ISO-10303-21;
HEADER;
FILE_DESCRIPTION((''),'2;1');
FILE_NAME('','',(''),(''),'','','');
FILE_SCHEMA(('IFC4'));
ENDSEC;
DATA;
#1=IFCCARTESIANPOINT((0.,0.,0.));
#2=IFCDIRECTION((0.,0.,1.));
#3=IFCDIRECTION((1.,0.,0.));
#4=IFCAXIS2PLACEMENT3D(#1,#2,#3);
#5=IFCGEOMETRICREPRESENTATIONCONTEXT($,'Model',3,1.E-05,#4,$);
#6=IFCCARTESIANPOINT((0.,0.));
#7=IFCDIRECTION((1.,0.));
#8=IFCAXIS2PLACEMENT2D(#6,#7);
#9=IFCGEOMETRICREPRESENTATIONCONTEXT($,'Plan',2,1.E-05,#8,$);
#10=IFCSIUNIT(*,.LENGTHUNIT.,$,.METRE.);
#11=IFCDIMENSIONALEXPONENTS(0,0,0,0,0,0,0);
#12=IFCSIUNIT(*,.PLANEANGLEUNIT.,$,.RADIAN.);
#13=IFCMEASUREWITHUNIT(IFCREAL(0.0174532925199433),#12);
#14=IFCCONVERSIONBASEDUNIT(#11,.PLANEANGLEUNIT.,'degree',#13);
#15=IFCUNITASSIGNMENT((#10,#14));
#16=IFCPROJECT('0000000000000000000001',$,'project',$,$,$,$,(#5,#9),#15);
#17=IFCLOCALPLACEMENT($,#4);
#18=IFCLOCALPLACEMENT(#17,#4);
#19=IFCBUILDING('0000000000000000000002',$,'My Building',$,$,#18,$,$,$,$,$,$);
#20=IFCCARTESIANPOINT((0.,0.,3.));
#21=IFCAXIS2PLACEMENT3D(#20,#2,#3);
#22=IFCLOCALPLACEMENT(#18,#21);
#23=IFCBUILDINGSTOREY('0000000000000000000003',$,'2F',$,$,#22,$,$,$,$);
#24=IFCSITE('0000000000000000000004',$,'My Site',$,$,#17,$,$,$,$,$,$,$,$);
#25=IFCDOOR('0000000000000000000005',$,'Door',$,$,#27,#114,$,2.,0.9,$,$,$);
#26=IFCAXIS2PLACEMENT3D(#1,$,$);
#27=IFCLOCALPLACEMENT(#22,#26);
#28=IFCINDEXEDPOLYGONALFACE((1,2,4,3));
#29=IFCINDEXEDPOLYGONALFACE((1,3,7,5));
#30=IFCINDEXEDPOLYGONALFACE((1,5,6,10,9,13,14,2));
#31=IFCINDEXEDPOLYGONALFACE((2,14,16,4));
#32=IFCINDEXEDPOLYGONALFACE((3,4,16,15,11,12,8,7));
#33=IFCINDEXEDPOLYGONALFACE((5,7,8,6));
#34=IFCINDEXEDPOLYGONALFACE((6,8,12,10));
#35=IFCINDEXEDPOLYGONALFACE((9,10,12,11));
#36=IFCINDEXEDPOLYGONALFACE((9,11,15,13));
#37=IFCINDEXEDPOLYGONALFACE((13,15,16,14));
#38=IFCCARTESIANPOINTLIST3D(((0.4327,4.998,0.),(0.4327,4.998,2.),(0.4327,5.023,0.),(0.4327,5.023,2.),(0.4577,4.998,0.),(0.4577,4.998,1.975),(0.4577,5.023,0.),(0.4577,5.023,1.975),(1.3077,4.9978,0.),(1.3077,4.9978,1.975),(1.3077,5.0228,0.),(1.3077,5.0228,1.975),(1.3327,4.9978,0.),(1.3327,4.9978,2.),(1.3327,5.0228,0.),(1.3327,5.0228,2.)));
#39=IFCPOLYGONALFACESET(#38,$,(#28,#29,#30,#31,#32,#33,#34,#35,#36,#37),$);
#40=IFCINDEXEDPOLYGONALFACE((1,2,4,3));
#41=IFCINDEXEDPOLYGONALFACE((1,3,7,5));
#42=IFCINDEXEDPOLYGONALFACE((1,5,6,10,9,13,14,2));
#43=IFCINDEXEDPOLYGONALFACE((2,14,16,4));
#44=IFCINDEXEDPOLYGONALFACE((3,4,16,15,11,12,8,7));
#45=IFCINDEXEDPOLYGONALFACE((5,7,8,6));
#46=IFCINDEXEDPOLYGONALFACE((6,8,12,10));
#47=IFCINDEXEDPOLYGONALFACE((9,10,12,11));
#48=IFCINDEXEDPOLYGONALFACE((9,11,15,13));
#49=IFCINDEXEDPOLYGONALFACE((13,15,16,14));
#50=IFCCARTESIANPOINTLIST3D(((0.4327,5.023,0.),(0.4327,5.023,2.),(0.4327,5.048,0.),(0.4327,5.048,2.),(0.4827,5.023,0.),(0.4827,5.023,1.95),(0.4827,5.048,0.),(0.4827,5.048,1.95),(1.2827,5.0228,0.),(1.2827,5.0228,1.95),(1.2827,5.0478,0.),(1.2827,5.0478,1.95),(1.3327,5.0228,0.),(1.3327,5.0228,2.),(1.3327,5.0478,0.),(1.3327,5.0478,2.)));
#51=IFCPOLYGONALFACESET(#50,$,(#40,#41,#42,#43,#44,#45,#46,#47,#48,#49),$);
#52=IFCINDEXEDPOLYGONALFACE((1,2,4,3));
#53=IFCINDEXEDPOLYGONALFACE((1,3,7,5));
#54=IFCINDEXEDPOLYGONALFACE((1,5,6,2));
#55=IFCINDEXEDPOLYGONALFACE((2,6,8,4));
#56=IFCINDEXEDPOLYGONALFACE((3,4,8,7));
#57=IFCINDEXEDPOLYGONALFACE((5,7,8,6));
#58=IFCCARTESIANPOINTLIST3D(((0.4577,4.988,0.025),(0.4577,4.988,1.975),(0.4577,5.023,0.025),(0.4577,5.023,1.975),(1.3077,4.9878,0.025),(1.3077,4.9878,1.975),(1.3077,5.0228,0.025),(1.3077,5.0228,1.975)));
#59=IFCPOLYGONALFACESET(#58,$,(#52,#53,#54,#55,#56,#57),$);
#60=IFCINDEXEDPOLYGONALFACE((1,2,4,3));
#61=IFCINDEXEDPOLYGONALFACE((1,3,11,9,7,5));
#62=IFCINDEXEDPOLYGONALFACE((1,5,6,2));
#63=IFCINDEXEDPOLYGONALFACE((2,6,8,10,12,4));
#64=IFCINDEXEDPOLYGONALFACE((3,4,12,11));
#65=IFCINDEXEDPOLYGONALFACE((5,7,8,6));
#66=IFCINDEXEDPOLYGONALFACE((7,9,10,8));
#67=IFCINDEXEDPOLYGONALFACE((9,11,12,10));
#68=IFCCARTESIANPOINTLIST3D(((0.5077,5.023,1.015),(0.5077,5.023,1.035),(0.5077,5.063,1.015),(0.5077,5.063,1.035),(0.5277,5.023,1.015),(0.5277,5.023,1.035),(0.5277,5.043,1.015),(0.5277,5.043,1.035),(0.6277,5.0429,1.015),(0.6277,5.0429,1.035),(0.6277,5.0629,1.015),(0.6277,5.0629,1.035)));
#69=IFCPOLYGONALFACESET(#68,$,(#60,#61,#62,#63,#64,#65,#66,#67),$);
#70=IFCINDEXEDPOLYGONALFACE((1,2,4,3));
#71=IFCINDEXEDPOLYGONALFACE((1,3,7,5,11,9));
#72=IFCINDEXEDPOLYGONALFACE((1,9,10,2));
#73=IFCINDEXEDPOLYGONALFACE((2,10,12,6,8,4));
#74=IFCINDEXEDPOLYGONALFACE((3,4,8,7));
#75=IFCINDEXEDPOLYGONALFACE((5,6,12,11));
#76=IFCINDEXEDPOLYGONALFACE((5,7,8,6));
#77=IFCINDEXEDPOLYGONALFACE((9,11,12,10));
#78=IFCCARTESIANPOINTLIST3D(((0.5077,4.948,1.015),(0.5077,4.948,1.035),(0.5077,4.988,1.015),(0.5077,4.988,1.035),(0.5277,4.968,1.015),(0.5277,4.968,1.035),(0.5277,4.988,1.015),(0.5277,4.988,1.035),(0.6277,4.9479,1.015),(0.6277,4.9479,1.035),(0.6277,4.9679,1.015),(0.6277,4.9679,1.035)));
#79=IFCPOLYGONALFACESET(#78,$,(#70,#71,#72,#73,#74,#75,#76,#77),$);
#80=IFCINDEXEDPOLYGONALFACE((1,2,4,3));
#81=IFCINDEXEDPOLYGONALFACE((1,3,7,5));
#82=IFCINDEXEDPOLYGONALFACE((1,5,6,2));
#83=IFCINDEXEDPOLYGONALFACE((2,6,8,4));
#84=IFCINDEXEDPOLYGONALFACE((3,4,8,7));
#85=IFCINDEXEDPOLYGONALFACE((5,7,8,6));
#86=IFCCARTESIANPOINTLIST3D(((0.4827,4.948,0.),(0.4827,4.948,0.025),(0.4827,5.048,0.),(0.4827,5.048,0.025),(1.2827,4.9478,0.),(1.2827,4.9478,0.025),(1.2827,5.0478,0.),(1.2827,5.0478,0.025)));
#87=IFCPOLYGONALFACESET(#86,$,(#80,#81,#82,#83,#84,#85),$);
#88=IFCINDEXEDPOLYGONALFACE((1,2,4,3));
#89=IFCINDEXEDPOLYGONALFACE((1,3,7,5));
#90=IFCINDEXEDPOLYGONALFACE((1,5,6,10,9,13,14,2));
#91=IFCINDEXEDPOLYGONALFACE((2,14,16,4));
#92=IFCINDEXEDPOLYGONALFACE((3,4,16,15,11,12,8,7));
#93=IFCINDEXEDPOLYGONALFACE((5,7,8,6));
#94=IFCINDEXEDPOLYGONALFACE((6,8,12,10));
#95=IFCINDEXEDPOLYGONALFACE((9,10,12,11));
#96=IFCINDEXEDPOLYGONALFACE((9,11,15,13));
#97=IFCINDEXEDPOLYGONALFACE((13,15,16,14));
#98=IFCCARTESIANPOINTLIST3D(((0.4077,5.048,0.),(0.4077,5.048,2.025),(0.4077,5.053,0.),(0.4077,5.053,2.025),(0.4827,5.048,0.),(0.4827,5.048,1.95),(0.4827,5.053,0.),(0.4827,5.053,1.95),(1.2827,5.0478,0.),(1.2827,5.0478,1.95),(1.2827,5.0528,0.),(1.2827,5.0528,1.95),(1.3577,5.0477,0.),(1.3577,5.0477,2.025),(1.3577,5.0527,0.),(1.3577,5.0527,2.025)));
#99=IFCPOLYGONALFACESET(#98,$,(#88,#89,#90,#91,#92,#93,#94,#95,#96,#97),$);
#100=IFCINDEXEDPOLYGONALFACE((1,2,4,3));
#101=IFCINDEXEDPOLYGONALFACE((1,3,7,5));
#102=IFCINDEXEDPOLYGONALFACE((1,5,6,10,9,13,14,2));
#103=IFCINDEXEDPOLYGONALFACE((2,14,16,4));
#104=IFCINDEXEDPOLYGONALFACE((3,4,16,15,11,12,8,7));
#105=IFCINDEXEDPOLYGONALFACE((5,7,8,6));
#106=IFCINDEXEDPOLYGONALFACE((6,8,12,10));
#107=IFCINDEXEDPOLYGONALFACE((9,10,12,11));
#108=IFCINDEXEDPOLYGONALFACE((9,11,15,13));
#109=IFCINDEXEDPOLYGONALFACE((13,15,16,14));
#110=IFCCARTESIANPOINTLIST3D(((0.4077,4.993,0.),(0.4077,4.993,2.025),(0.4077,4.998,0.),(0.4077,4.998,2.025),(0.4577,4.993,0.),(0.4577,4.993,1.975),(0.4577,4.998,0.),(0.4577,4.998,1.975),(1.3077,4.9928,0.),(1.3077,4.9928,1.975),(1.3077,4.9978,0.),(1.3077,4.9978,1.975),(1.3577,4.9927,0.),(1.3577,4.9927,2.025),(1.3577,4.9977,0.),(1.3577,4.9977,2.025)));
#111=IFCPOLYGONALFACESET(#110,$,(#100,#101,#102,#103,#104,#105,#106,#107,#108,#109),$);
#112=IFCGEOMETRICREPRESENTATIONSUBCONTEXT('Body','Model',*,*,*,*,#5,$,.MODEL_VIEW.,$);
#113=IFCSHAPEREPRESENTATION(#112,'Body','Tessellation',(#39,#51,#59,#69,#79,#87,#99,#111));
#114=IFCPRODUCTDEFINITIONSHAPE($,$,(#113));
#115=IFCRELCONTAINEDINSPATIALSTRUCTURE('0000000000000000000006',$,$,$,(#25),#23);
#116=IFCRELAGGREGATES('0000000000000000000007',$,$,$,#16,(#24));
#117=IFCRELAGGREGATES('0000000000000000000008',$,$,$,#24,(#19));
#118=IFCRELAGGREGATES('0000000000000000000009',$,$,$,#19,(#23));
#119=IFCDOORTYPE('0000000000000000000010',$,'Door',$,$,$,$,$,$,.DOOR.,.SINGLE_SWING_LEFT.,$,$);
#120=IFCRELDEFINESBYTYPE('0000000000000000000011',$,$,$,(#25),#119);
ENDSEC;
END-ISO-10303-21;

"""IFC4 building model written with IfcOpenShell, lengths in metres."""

from ifc_helpers import new_model, entity, si_unit, converted_unit, frame, origin_with_axes, origin_2d_with_axis, place, context, subcontext, project, spatial, line, indexed_curve, outline, extrude, shape, source, transform, mapped, type_object, type_shapes, element, save


model = new_model("IFC4")

# Units and contexts
model_context = context("Model", 3, precision=1e-05, world=origin_with_axes())
plan_context = context("Plan", 2, precision=1e-05, world=origin_2d_with_axis())
body_context_1 = subcontext(model_context, "Body", "Model", "MODEL_VIEW")
body_context_2 = subcontext(plan_context, "Body", "Plan", "PLAN_VIEW")
ifc_project = project(units=[si_unit("LENGTHUNIT", "METRE"), converted_unit("PLANEANGLEUNIT", "degree", entity("IfcReal", 0.0174532925199433), si_unit("PLANEANGLEUNIT", "RADIAN"), dimensions=[0, 0, 0, 0, 0, 0, 0])], contexts=[model_context, plan_context])

# Site, building, storey
site_placement = place(None, origin_with_axes())
site = spatial("IfcSite", under=ifc_project, at=site_placement, Name="My Site")
building_placement = place(site_placement, origin_with_axes())
building = spatial("IfcBuilding", under=site, at=building_placement, Name="My Building")
storey_placement = place(building_placement, frame((0.0, 0.0, 3.0), z_axis=(0.0, 0.0, 1.0), x_axis=(1.0, 0.0, 0.0)))
storey = spatial("IfcBuildingStorey", under=building, at=storey_placement, Name="2F")

# Shared definitions
door_type_1 = type_object("IfcDoorType", Name="Door", OperationType="SINGLE_SWING_LEFT", PredefinedType="DOOR")
shared_shape_1 = source(origin_with_axes(), body_context_1, "Body", "SweptSolid", [
    extrude(outline(indexed_curve([(0.0, 0.0), (0.0, 2.0), (0.9, 2.0), (0.9, 0.0), (0.875, 0.0), (0.875, 1.975), (0.025, 1.975), (0.025, 0.0)], segments=[line(1, 2, 3, 4, 5, 6, 7, 8, 1)])), frame((0.0, 0.025, 0.0), z_axis=(0.0, -1.0, 0.0), x_axis=(1.0, 0.0, 0.0)), (0.0, 0.0, -1.0), 0.025),
    extrude(outline(indexed_curve([(0.0, 0.0), (0.0, 2.0), (0.9, 2.0), (0.9, 0.0), (0.85, 0.0), (0.85, 1.95), (0.05, 1.95), (0.05, 0.0)], segments=[line(1, 2, 3, 4, 5, 6, 7, 8, 1)])), frame((0.0, 0.0, 0.0), z_axis=(0.0, -1.0, 0.0), x_axis=(1.0, 0.0, 0.0)), (0.0, 0.0, -1.0), 0.025),
    extrude(outline(indexed_curve([(0.0, 0.0), (0.85, 0.0), (0.85, 0.035), (0.0, 0.035)], segments=[line(1, 2, 3, 4, 1)])), frame((0.025, 0.025, 0.025), z_axis=(0.0, 0.0, 1.0), x_axis=(1.0, 0.0, 0.0)), (0.0, 0.0, 1.0), 1.95),
    extrude(outline(indexed_curve([(0.0, 0.0), (0.0, -0.04), (-0.12, -0.04), (-0.12, -0.02), (-0.02, -0.02), (-0.02, 0.0)], segments=[line(1, 2, 3, 4, 5, 6, 1)])), frame((0.825, 0.025, 1.015), z_axis=(0.0, 0.0, 1.0), x_axis=(1.0, 0.0, 0.0)), (0.0, 0.0, 1.0), 0.02),
    extrude(outline(indexed_curve([(0.0, 0.0), (0.0, 0.04), (-0.12, 0.04), (-0.12, 0.02), (-0.02, 0.02), (-0.02, 0.0)], segments=[line(1, 2, 3, 4, 5, 6, 1)])), frame((0.825, 0.06, 1.015), z_axis=(0.0, 0.0, 1.0), x_axis=(1.0, 0.0, 0.0)), (0.0, 0.0, 1.0), 0.02),
    extrude(outline(indexed_curve([(0.0, 0.0), (0.8, 0.0), (0.8, 0.1), (0.0, 0.1)], segments=[line(1, 2, 3, 4, 1)])), frame((0.05, 0.0, 0.0), z_axis=(0.0, 0.0, 1.0), x_axis=(1.0, 0.0, 0.0)), (0.0, 0.0, 1.0), 0.025),
    extrude(outline(indexed_curve([(0.0, 0.0), (0.0, 2.025), (0.95, 2.025), (0.95, 0.0), (0.875, 0.0), (0.875, 1.95), (0.075, 1.95), (0.075, 0.0)], segments=[line(1, 2, 3, 4, 5, 6, 7, 8, 1)])), frame((-0.025, -0.005, 0.0), z_axis=(0.0, -1.0, 0.0), x_axis=(1.0, 0.0, 0.0)), (0.0, 0.0, -1.0), 0.005),
    extrude(outline(indexed_curve([(0.0, 0.0), (0.0, 2.025), (0.95, 2.025), (0.95, 0.0), (0.9, 0.0), (0.9, 1.975), (0.05, 1.975), (0.05, 0.0)], segments=[line(1, 2, 3, 4, 5, 6, 7, 8, 1)])), frame((-0.025, 0.05, 0.0), z_axis=(0.0, -1.0, 0.0), x_axis=(1.0, 0.0, 0.0)), (0.0, 0.0, -1.0), 0.005),
])
shared_shape_2 = source(origin_with_axes(), body_context_2, "Body", "Curve2D", [
    entity("IfcIndexedPolyCurve", entity("IfcCartesianPointList2D", [[0.0, 0.0], [0.0, 0.05], [0.025, 0.05], [0.025, 0.025], [0.05, 0.025], [0.05, 0.0]]), [entity("IfcLineIndex", [1, 2, 3, 4, 5, 6, 1])]),
    entity("IfcIndexedPolyCurve", entity("IfcCartesianPointList2D", [[0.9, 0.0], [0.9, 0.05], [0.875, 0.05], [0.875, 0.025], [0.85, 0.025], [0.85, 0.0]]), [entity("IfcLineIndex", [1, 2, 3, 4, 5, 6, 1])]),
    entity("IfcTrimmedCurve", entity("IfcEllipse", entity("IfcAxis2Placement2D", entity("IfcCartesianPoint", [0.06, 0.05]), entity("IfcDirection", [1.0, 0.0])), 0.815, 0.85), [entity("IfcCartesianPoint", [0.875, 0.05])], [entity("IfcCartesianPoint", [0.06, 0.9])], True, "CARTESIAN"),
    entity("IfcIndexedPolyCurve", entity("IfcCartesianPointList2D", [[0.025, 0.05], [0.06, 0.05], [0.06, 0.9], [0.025, 0.9]]), [entity("IfcLineIndex", [1, 2, 3, 4, 1])]),
])
type_shapes(door_type_1, [shared_shape_1, shared_shape_2])

# Door
placement_1 = place(storey_placement, frame((4.126, 5.047, 0.0), z_axis=(0.0, 0.0, 1.0), x_axis=(-1.0, 0.000274, 0.0)))
placement_2 = place(placement_1, frame((2.7933, 0.0, 0.0), z_axis=(0.0, 0.0, 1.0), x_axis=(1.0, 0.0, 0.0)))
door_1_placement = place(placement_2, frame((0.0, 0.0, 0.0), z_axis=(0.0, 0.0, 1.0), x_axis=(1.0, 0.0, 0.0)))
element("IfcDoor", 1, at=door_1_placement, inside=storey, type_object=door_type_1, Name="Door", OverallHeight=2.0, OverallWidth=0.9, shapes=[
    shape(body_context_1, "Body", "MappedRepresentation", [mapped(shared_shape_1, transform((0.0, 0.0, 0.0), x_axis=(1.0, 0.0, 0.0), y_axis=(0.0, 1.0, 0.0), z_axis=(0.0, 0.0, 1.0), scale=1.0))]),
    shape(body_context_2, "Body", "MappedRepresentation", [mapped(shared_shape_2, transform((0.0, 0.0, 0.0), x_axis=(1.0, 0.0, 0.0), y_axis=(0.0, 1.0, 0.0), z_axis=(0.0, 0.0, 1.0), scale=1.0))]),
])

save(model, "model.ifc")
